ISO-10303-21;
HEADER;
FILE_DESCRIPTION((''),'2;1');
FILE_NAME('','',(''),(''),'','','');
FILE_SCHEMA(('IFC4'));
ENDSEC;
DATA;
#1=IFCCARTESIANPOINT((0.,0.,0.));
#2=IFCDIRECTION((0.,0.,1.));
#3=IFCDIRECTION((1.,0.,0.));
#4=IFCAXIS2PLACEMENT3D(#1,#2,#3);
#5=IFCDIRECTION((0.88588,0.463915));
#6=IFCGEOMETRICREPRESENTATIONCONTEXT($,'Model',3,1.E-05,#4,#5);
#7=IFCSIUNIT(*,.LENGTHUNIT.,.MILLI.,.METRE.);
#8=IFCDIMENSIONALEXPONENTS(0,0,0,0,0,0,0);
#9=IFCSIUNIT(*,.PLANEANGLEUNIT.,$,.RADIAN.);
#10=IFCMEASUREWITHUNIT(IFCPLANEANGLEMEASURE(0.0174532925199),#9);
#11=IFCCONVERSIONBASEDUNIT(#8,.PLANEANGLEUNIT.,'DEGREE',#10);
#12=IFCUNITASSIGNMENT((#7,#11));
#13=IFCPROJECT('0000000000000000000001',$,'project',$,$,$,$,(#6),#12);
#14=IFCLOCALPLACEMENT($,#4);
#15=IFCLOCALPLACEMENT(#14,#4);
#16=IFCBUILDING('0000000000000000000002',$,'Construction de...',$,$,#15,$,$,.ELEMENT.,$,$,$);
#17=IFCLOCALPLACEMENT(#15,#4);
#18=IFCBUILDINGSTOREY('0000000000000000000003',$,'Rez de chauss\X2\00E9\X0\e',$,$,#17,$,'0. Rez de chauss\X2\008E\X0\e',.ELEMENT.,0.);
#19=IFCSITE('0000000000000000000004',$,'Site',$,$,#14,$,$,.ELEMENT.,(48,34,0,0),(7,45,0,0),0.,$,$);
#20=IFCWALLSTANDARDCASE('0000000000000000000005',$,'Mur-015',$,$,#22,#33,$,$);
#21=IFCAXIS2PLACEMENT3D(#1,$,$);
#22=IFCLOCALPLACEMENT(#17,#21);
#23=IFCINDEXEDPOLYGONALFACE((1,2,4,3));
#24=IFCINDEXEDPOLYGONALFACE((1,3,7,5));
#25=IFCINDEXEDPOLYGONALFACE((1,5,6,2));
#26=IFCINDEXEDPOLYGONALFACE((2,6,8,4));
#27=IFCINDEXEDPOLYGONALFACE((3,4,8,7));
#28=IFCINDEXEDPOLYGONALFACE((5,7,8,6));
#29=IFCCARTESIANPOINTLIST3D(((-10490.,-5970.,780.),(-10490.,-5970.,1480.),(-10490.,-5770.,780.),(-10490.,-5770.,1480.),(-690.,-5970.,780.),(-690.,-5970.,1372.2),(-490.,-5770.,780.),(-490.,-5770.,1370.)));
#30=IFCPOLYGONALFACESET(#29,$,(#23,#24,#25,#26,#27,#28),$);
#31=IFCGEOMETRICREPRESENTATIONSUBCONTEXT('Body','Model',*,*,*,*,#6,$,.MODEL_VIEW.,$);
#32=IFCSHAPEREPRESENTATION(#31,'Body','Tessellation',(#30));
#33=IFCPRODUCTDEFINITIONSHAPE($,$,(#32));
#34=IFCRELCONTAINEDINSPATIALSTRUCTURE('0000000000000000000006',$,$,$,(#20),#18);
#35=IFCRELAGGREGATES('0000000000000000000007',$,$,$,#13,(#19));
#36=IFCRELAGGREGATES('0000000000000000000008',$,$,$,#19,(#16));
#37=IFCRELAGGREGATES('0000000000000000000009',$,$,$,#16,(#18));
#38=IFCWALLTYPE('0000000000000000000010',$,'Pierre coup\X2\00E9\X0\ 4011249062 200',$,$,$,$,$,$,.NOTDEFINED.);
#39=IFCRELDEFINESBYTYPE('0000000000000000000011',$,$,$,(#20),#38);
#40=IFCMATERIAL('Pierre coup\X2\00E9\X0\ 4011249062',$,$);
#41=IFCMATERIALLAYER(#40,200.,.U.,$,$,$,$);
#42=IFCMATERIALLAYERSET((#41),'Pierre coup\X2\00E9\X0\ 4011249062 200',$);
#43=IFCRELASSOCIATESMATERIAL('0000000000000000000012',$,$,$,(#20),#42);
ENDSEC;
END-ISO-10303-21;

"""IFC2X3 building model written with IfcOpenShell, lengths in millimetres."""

from ifc_helpers import new_model, entity, si_unit, converted_unit, direction, frame, origin_with_axes, place, context, subcontext, project, spatial, polyline, outline, extrude, clip, halfspace, material, layer, layer_set, layer_usage, type_object, element, save


model = new_model("IFC2X3")

# Units and contexts
model_context = context("Model", 3, precision=1e-05, world=origin_with_axes(), true_north=direction((0.88588, 0.463915)))
body_context = subcontext(model_context, "Body", "Model", "MODEL_VIEW")
ifc_project = project(units=[si_unit("LENGTHUNIT", "METRE", prefix="MILLI"), converted_unit("PLANEANGLEUNIT", "DEGREE", entity("IfcPlaneAngleMeasure", 0.0174532925199), si_unit("PLANEANGLEUNIT", "RADIAN"), dimensions=[0, 0, 0, 0, 0, 0, 0])], contexts=[model_context])

# Site, building, storey
site_placement = place(None, origin_with_axes())
site = spatial("IfcSite", under=ifc_project, at=site_placement, Name="Site", CompositionType="ELEMENT", RefLatitude=(48, 34, 0, 0), RefLongitude=(7, 45, 0, 0), RefElevation=0.0)
building_placement = place(site_placement, origin_with_axes())
building = spatial("IfcBuilding", under=site, at=building_placement, Name="Construction de...", CompositionType="ELEMENT")
storey_placement = place(building_placement, origin_with_axes())
storey = spatial("IfcBuildingStorey", under=building, at=storey_placement, Name="Rez de chaussée", LongName="0. Rez de chauss\u008ee", CompositionType="ELEMENT", Elevation=0.0)

# Wall
ifc_material_1 = material(Name="Pierre coupé 4011249062")
ifc_layer_1 = layer(ifc_material_1, 200.0, ventilated="UNKNOWN")
ifc_layer_set_1 = layer_set([ifc_layer_1], Name="Pierre coupé 4011249062 200")
wall_type_1 = type_object("IfcWallType", Name="Pierre coupé 4011249062 200", PredefinedType="NOTDEFINED")
ifc_layer_usage_1 = layer_usage(ifc_layer_set_1, "AXIS2", "NEGATIVE", 100.0)
wall_1_placement = place(storey_placement, frame((-10490.0, -5870.0, 780.0), z_axis=(0.0, 0.0, 1.0), x_axis=(1.0, 0.0, 0.0)))
element("IfcWallStandardCase", 1, at=wall_1_placement, inside=storey, type_object=wall_type_1, material=ifc_layer_usage_1, Name="Mur-015", context=body_context, shape_type="Clipping", body=[
    clip(extrude(outline(polyline([(0.0, -100.0), (9800.0, -100.0), (10000.0, 100.0), (0.0, 100.0), (0.0, -100.0)])), origin_with_axes(), (0.0, 0.0, 1.0), 700.0), halfspace(frame((7.7, 0.0, 699.9), z_axis=(-0.010999, 0.0, -0.99994), x_axis=(0.0, 1.0, 0.0)), True)),
])

save(model, "model.ifc")
